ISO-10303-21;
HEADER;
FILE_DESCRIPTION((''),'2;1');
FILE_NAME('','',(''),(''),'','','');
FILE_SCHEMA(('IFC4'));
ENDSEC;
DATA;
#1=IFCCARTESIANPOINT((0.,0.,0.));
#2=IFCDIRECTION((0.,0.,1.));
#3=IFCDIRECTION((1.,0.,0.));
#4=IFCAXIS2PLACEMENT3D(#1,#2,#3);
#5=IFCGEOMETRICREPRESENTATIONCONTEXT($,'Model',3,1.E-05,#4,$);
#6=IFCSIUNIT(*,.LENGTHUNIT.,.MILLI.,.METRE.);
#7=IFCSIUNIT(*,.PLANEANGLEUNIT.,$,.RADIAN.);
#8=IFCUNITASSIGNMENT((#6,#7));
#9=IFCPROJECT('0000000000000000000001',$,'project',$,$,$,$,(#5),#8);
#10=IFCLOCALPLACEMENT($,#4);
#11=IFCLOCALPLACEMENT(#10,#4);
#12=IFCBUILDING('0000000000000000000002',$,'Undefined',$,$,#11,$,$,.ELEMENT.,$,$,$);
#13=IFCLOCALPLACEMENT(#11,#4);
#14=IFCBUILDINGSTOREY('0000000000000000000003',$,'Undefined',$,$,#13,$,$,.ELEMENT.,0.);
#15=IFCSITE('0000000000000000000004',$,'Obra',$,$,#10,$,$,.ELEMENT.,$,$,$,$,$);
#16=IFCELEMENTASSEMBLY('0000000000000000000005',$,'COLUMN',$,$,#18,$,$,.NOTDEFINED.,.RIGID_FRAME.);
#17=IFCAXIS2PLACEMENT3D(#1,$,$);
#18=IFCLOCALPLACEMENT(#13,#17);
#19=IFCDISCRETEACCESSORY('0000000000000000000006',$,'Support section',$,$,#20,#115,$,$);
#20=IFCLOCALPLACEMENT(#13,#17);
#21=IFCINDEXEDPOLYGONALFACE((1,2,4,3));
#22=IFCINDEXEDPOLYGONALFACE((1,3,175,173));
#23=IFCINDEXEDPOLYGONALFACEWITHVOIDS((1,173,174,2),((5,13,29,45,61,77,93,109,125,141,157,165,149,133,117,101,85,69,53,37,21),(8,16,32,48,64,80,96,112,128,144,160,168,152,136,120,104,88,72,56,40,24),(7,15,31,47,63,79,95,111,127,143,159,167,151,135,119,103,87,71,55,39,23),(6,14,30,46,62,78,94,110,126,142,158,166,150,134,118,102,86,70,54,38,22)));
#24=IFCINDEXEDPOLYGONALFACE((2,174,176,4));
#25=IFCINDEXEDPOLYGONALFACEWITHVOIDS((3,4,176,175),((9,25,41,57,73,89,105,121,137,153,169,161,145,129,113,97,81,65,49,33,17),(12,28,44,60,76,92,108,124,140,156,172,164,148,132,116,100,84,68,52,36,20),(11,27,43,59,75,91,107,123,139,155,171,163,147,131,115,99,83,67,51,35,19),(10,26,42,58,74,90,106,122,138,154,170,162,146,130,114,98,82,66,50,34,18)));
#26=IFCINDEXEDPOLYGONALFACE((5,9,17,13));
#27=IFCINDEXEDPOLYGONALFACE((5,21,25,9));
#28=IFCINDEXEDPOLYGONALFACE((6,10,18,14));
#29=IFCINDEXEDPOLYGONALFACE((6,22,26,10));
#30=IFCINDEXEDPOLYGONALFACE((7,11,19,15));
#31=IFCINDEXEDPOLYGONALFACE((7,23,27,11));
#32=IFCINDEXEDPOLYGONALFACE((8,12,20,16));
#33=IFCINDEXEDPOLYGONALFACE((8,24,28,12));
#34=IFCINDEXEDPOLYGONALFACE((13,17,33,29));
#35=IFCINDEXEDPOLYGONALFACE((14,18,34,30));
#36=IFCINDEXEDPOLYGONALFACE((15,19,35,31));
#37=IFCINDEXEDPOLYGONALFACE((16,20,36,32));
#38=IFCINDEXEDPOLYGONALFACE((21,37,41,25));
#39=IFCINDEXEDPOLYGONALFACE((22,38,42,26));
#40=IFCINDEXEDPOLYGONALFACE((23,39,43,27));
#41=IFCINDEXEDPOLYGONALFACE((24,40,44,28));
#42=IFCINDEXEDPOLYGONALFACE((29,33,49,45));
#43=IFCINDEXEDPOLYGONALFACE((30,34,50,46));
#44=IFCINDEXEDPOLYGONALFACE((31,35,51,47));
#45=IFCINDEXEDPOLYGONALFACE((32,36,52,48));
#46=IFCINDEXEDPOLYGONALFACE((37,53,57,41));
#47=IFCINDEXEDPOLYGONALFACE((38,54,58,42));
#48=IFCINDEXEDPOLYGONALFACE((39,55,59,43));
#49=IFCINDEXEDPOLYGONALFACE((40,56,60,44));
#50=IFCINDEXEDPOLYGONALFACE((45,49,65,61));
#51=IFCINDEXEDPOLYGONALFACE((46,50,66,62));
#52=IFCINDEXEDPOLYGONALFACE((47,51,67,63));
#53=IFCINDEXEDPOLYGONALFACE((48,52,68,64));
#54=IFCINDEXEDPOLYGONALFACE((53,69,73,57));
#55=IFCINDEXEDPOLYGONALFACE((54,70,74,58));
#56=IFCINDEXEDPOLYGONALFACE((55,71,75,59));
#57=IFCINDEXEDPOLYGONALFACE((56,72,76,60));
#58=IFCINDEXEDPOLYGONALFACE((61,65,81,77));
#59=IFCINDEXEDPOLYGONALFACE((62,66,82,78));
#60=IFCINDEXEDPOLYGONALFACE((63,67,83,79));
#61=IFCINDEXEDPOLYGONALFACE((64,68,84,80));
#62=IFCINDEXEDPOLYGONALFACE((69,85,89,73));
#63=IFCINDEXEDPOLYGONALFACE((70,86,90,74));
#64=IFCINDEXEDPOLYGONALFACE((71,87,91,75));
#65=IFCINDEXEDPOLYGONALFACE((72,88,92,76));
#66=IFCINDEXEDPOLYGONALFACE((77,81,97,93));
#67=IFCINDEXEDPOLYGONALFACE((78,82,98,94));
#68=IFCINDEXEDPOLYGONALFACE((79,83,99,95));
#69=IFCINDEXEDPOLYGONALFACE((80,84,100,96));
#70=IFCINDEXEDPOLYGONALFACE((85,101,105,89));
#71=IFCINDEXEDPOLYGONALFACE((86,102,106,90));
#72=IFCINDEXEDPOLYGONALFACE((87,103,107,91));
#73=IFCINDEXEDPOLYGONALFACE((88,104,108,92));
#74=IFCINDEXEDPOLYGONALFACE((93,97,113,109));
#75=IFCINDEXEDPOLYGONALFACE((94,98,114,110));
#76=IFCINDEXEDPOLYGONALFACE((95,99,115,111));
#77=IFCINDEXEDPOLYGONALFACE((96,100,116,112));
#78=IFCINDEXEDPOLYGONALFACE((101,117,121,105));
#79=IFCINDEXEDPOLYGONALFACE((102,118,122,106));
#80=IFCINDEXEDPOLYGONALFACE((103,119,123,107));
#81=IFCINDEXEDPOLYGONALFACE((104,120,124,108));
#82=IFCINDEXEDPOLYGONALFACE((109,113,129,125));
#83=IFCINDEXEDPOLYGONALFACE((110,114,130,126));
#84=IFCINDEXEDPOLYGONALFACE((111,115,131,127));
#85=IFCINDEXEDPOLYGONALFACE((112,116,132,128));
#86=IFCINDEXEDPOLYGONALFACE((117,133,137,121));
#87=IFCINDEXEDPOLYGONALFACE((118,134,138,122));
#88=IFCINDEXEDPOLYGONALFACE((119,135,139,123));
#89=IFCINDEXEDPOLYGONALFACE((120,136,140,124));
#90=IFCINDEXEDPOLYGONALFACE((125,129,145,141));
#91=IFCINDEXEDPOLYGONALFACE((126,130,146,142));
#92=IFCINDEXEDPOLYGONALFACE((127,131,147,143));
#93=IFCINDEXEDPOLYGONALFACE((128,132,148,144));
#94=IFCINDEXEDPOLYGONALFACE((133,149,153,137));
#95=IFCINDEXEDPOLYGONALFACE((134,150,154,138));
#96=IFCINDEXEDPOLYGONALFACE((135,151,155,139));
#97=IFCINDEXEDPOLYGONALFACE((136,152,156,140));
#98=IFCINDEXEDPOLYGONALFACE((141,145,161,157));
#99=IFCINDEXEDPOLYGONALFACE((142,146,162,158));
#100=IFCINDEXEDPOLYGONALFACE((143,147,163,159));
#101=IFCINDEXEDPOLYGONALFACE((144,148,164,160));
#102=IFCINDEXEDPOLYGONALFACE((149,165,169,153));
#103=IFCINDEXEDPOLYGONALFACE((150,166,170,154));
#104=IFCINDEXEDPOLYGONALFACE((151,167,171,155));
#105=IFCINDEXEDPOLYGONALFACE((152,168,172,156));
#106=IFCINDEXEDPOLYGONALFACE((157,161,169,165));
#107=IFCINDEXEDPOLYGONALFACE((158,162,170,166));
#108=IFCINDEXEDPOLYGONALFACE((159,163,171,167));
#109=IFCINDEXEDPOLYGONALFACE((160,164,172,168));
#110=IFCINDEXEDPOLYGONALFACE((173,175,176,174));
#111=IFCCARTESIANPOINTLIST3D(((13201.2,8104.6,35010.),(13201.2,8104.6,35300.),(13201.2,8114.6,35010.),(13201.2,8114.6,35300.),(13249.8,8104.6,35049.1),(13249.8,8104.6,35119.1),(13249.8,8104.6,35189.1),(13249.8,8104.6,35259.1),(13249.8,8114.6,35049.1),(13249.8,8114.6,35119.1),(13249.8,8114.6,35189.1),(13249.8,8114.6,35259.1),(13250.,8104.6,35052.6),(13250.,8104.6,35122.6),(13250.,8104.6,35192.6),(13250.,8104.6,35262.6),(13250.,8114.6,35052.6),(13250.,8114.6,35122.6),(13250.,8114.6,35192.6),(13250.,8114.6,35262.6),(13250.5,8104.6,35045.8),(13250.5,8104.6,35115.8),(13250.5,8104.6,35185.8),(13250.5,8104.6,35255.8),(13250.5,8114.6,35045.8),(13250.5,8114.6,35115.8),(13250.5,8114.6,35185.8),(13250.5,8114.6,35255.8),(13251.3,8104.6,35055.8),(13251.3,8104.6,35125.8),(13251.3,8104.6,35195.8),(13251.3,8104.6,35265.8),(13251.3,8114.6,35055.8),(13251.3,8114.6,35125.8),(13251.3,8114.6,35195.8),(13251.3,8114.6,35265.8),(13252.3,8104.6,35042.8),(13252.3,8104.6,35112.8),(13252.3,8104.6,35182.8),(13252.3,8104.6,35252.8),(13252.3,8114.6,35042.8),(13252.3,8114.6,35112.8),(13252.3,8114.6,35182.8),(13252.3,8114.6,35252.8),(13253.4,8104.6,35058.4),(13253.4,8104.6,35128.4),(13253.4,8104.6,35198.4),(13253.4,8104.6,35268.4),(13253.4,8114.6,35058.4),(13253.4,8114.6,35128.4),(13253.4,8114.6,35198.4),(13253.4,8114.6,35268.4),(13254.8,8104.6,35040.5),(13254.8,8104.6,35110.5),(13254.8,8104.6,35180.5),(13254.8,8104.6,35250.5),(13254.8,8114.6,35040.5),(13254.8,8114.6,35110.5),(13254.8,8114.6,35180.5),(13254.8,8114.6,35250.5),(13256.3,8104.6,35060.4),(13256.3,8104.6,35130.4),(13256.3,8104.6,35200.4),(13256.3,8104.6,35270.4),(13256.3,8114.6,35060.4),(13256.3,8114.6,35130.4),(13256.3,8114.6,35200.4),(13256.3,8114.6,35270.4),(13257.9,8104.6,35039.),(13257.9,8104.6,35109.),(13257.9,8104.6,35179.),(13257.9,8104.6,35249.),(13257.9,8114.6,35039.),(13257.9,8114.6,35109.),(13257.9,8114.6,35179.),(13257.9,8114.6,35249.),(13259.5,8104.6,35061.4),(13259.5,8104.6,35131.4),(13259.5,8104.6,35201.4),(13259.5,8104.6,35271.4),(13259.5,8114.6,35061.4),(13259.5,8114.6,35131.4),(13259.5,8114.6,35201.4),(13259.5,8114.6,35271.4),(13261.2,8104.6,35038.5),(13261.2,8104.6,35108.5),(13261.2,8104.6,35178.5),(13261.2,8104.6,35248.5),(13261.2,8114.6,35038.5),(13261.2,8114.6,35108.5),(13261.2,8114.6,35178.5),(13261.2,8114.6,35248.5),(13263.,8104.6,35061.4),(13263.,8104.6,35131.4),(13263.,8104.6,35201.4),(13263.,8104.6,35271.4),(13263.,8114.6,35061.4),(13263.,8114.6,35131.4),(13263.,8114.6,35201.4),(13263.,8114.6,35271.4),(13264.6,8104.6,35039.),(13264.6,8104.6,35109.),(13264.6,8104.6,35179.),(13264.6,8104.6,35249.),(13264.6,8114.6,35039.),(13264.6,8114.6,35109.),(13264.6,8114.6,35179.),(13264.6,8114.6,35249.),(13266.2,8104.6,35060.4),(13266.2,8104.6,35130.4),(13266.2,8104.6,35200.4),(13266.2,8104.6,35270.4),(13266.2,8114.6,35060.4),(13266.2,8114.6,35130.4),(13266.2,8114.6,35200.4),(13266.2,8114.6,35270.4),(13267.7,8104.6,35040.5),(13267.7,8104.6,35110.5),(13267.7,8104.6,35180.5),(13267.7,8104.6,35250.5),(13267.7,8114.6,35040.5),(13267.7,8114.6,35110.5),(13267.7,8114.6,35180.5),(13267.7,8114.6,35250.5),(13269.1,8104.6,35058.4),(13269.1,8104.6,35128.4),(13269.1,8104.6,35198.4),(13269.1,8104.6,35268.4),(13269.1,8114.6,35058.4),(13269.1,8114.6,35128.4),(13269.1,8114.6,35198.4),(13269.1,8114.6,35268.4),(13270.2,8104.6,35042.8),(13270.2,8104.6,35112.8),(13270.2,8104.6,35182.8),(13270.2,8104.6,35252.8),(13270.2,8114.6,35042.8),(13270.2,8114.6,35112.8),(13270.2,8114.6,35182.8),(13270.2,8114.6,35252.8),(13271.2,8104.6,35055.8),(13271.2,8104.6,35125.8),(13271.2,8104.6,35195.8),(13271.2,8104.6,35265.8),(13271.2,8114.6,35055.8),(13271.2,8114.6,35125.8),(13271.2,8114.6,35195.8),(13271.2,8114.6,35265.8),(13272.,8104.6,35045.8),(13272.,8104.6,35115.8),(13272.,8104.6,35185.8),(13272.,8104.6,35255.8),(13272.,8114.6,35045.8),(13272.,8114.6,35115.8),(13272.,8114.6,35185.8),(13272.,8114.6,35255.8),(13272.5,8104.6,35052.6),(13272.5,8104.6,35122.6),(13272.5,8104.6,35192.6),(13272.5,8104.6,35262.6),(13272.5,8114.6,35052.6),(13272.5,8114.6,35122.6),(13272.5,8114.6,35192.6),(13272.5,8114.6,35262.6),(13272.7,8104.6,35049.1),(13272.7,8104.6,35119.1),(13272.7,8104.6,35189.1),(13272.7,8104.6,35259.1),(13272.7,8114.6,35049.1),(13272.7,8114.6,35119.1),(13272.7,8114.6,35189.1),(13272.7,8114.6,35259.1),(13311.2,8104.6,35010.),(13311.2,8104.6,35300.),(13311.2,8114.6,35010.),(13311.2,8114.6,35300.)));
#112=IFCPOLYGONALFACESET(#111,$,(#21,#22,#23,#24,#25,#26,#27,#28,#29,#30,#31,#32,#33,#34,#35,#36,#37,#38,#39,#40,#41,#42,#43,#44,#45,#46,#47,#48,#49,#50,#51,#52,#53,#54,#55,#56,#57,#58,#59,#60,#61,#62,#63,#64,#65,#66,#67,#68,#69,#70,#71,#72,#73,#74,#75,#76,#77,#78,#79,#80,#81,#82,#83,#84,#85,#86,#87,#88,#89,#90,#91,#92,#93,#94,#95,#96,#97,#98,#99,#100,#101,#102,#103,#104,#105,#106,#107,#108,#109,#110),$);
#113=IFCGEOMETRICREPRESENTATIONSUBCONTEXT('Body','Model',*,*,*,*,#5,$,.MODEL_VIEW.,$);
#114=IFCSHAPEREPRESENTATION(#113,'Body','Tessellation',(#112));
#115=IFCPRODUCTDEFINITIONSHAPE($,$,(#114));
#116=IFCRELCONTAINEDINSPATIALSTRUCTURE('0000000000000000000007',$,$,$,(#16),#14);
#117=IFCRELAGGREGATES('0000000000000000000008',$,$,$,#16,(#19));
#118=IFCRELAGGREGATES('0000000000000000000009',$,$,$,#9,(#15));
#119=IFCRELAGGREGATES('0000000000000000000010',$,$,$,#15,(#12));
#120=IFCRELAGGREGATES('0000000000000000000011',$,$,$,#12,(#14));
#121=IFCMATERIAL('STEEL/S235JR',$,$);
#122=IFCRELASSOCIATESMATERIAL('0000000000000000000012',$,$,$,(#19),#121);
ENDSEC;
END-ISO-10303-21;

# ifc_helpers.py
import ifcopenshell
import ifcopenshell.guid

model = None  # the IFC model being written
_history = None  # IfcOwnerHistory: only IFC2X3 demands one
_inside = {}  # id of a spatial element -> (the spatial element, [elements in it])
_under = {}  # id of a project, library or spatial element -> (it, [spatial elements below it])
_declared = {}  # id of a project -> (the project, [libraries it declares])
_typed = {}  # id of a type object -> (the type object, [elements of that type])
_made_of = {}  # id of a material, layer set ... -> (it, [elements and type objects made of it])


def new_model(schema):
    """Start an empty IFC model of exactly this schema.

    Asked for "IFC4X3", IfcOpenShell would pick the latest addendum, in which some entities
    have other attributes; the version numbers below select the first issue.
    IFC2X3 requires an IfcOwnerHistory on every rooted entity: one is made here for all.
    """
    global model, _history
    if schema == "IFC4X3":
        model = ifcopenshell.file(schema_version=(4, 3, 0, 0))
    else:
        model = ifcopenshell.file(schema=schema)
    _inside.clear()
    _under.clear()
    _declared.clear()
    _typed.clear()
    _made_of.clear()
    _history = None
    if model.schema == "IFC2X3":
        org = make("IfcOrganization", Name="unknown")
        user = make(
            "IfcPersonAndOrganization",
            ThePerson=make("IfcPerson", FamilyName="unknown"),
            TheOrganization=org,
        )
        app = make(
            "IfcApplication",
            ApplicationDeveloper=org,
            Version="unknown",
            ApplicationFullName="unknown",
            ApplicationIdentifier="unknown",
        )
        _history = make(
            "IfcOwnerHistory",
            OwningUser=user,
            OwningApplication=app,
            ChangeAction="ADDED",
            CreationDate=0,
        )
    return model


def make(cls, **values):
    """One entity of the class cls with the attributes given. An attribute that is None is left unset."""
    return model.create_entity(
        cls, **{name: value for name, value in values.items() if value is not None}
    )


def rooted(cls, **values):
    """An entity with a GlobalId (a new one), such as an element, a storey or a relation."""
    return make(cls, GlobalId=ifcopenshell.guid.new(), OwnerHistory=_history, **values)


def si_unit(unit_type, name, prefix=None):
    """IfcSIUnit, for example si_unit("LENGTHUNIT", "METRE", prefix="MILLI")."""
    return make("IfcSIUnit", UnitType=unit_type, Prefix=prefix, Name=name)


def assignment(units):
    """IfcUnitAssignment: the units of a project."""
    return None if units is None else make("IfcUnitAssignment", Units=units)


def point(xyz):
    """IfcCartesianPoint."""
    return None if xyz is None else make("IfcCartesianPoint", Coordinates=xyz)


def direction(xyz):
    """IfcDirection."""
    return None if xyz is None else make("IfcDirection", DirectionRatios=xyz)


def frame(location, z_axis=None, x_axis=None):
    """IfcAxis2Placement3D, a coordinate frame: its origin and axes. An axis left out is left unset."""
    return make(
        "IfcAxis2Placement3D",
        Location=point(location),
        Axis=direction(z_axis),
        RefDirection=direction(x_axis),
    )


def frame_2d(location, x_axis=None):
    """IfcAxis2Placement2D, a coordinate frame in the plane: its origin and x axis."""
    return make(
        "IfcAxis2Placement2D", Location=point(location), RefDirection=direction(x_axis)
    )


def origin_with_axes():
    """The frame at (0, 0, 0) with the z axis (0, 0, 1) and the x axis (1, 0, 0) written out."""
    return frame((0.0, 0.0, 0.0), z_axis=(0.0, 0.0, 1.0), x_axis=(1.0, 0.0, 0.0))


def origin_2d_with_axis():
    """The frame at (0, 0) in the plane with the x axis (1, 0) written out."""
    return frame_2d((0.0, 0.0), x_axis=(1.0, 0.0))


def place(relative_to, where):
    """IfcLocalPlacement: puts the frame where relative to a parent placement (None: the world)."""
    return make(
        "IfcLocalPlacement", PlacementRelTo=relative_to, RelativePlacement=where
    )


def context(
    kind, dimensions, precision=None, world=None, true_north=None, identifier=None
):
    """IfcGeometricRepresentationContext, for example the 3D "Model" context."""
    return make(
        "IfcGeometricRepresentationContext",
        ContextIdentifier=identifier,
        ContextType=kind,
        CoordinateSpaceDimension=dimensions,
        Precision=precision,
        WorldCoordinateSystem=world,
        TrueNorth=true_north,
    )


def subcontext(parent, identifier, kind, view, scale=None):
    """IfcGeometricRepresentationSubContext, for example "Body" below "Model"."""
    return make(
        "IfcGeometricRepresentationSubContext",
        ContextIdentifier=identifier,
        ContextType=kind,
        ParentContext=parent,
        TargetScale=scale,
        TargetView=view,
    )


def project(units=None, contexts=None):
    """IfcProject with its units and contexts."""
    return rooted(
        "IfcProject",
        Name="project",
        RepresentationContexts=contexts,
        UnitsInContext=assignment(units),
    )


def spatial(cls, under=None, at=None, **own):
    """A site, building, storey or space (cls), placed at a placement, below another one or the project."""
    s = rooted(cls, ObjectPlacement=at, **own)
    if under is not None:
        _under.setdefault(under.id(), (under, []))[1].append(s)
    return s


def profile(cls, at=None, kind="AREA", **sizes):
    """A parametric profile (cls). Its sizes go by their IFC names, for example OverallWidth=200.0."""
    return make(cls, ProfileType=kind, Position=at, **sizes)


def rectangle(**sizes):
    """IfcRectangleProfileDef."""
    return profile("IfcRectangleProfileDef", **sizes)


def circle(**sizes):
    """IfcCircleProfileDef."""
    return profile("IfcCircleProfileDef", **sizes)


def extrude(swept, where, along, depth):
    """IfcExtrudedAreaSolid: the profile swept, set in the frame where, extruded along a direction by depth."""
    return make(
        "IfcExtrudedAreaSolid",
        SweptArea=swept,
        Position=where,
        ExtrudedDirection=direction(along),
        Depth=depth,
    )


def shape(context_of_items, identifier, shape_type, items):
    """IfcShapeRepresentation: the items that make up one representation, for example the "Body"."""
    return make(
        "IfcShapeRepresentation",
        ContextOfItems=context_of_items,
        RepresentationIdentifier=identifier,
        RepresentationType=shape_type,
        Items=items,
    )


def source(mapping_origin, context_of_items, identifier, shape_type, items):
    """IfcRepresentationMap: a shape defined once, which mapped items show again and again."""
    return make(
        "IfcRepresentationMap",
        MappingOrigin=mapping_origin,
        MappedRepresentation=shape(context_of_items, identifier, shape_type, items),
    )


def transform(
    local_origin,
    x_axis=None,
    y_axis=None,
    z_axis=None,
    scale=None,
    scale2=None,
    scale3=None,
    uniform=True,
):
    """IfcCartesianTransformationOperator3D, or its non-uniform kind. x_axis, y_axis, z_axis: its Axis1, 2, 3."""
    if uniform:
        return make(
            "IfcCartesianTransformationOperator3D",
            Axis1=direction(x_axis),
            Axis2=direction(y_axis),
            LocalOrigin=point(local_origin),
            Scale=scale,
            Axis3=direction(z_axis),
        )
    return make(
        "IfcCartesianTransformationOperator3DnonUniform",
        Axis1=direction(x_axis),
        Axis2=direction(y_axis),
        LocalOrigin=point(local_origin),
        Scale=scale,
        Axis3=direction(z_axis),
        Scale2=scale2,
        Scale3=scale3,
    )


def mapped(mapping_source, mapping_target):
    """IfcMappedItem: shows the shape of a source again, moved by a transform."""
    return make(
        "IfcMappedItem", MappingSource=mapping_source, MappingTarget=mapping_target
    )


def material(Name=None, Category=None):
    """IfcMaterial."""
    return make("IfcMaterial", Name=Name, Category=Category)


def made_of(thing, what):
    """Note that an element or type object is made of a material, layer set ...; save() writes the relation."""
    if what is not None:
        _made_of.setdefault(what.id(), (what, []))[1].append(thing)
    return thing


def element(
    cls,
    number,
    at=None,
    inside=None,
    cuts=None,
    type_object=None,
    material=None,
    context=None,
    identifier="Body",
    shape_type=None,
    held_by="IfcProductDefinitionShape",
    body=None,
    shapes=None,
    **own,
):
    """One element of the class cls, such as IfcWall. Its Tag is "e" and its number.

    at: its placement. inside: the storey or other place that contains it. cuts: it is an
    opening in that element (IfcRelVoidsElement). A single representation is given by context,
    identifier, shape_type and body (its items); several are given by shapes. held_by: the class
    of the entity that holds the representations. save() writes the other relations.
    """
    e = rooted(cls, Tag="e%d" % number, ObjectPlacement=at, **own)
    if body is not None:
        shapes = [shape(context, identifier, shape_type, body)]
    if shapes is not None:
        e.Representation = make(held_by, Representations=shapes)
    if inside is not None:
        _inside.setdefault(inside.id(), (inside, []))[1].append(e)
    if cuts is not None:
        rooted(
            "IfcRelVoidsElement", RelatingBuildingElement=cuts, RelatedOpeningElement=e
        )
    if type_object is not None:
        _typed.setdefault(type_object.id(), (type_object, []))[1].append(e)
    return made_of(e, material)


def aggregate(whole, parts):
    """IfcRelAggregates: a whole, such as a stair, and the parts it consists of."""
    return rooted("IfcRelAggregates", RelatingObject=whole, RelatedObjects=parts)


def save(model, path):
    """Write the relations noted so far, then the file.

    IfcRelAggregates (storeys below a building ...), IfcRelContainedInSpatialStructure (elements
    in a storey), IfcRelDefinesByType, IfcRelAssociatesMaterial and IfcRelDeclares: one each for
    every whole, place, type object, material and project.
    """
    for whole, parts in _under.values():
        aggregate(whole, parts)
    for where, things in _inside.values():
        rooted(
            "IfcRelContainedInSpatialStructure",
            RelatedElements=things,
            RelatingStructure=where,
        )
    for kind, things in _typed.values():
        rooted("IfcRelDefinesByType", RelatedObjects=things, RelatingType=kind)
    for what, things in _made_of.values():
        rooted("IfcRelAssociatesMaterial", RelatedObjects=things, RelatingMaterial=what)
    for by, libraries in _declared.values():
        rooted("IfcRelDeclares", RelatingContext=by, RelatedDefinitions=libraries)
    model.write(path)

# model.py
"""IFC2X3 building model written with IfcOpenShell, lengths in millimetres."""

from ifc_helpers import new_model, si_unit, frame, origin_with_axes, origin_2d_with_axis, place, context, subcontext, project, spatial, rectangle, circle, extrude, source, transform, mapped, material, element, aggregate, save


model = new_model("IFC2X3")

# Units and contexts
model_context = context("Model", 3, precision=1e-05, world=origin_with_axes())
body_context = subcontext(model_context, "Body", "Model", "MODEL_VIEW")
ifc_project = project(units=[si_unit("LENGTHUNIT", "METRE", prefix="MILLI"), si_unit("PLANEANGLEUNIT", "RADIAN")], contexts=[model_context])

# Site, building, storey
site_placement = place(None, origin_with_axes())
site = spatial("IfcSite", under=ifc_project, at=site_placement, Name="Obra", CompositionType="ELEMENT")
building_placement = place(site_placement, origin_with_axes())
building = spatial("IfcBuilding", under=site, at=building_placement, Name="Undefined", CompositionType="ELEMENT")
storey_placement = place(building_placement, origin_with_axes())
storey = spatial("IfcBuildingStorey", under=building, at=storey_placement, Name="Undefined", CompositionType="ELEMENT", Elevation=0.0)

# Element assembly
ifc_material_1 = material(Name="STEEL/S235JR")
assembly_1_placement = place(storey_placement, origin_with_axes())
assembly_1 = element("IfcElementAssembly", 1, at=assembly_1_placement, inside=storey, Name="COLUMN", AssemblyPlace="NOTDEFINED", PredefinedType="RIGID_FRAME")

# Discrete accessory, opening
discrete_accessory_1_placement = place(assembly_1_placement, frame((13256.2, 8109.6, 35010.0), z_axis=(0.0, 0.0, 1.0), x_axis=(-1.0, 0.0, 0.0)))
discrete_accessory_1 = element("IfcDiscreteAccessory", 2, at=discrete_accessory_1_placement, material=ifc_material_1, Name="Support section", context=body_context, shape_type="SweptSolid", body=[
    extrude(rectangle(XDim=10.0, YDim=110.0, at=origin_2d_with_axis()), frame((0.0, 0.0, 290.0), z_axis=(0.0, 0.0, -1.0), x_axis=(0.0, 1.0, 0.0)), (0.0, 0.0, 1.0), 290.0),
])
shared_shape_1 = source(origin_with_axes(), body_context, "Body", "SweptSolid", [
    extrude(circle(Radius=11.5, at=origin_2d_with_axis()), frame((0.0, -15.6, 0.0), z_axis=(0.0, 1.0, 0.0), x_axis=(1.0, 0.0, 0.0)), (0.0, 0.0, 1.0), 10.2),
])
opening_1_placement = place(assembly_1_placement, frame((13211.2, 8120.1, 35350.0), z_axis=(1.0, 0.0, 0.0), x_axis=(0.0, 0.0, -1.0)))
element("IfcOpeningElement", 3, at=opening_1_placement, cuts=discrete_accessory_1, ObjectType="Opening", context=body_context, shape_type="MappedRepresentation", body=[
    mapped(shared_shape_1, transform((90.0, 0.0, 50.0))),
    mapped(shared_shape_1, transform((160.0, 0.0, 50.0))),
    mapped(shared_shape_1, transform((230.0, 0.0, 50.0))),
    mapped(shared_shape_1, transform((300.0, 0.0, 50.0))),
])
aggregate(assembly_1, [discrete_accessory_1])

save(model, "model.ifc")
